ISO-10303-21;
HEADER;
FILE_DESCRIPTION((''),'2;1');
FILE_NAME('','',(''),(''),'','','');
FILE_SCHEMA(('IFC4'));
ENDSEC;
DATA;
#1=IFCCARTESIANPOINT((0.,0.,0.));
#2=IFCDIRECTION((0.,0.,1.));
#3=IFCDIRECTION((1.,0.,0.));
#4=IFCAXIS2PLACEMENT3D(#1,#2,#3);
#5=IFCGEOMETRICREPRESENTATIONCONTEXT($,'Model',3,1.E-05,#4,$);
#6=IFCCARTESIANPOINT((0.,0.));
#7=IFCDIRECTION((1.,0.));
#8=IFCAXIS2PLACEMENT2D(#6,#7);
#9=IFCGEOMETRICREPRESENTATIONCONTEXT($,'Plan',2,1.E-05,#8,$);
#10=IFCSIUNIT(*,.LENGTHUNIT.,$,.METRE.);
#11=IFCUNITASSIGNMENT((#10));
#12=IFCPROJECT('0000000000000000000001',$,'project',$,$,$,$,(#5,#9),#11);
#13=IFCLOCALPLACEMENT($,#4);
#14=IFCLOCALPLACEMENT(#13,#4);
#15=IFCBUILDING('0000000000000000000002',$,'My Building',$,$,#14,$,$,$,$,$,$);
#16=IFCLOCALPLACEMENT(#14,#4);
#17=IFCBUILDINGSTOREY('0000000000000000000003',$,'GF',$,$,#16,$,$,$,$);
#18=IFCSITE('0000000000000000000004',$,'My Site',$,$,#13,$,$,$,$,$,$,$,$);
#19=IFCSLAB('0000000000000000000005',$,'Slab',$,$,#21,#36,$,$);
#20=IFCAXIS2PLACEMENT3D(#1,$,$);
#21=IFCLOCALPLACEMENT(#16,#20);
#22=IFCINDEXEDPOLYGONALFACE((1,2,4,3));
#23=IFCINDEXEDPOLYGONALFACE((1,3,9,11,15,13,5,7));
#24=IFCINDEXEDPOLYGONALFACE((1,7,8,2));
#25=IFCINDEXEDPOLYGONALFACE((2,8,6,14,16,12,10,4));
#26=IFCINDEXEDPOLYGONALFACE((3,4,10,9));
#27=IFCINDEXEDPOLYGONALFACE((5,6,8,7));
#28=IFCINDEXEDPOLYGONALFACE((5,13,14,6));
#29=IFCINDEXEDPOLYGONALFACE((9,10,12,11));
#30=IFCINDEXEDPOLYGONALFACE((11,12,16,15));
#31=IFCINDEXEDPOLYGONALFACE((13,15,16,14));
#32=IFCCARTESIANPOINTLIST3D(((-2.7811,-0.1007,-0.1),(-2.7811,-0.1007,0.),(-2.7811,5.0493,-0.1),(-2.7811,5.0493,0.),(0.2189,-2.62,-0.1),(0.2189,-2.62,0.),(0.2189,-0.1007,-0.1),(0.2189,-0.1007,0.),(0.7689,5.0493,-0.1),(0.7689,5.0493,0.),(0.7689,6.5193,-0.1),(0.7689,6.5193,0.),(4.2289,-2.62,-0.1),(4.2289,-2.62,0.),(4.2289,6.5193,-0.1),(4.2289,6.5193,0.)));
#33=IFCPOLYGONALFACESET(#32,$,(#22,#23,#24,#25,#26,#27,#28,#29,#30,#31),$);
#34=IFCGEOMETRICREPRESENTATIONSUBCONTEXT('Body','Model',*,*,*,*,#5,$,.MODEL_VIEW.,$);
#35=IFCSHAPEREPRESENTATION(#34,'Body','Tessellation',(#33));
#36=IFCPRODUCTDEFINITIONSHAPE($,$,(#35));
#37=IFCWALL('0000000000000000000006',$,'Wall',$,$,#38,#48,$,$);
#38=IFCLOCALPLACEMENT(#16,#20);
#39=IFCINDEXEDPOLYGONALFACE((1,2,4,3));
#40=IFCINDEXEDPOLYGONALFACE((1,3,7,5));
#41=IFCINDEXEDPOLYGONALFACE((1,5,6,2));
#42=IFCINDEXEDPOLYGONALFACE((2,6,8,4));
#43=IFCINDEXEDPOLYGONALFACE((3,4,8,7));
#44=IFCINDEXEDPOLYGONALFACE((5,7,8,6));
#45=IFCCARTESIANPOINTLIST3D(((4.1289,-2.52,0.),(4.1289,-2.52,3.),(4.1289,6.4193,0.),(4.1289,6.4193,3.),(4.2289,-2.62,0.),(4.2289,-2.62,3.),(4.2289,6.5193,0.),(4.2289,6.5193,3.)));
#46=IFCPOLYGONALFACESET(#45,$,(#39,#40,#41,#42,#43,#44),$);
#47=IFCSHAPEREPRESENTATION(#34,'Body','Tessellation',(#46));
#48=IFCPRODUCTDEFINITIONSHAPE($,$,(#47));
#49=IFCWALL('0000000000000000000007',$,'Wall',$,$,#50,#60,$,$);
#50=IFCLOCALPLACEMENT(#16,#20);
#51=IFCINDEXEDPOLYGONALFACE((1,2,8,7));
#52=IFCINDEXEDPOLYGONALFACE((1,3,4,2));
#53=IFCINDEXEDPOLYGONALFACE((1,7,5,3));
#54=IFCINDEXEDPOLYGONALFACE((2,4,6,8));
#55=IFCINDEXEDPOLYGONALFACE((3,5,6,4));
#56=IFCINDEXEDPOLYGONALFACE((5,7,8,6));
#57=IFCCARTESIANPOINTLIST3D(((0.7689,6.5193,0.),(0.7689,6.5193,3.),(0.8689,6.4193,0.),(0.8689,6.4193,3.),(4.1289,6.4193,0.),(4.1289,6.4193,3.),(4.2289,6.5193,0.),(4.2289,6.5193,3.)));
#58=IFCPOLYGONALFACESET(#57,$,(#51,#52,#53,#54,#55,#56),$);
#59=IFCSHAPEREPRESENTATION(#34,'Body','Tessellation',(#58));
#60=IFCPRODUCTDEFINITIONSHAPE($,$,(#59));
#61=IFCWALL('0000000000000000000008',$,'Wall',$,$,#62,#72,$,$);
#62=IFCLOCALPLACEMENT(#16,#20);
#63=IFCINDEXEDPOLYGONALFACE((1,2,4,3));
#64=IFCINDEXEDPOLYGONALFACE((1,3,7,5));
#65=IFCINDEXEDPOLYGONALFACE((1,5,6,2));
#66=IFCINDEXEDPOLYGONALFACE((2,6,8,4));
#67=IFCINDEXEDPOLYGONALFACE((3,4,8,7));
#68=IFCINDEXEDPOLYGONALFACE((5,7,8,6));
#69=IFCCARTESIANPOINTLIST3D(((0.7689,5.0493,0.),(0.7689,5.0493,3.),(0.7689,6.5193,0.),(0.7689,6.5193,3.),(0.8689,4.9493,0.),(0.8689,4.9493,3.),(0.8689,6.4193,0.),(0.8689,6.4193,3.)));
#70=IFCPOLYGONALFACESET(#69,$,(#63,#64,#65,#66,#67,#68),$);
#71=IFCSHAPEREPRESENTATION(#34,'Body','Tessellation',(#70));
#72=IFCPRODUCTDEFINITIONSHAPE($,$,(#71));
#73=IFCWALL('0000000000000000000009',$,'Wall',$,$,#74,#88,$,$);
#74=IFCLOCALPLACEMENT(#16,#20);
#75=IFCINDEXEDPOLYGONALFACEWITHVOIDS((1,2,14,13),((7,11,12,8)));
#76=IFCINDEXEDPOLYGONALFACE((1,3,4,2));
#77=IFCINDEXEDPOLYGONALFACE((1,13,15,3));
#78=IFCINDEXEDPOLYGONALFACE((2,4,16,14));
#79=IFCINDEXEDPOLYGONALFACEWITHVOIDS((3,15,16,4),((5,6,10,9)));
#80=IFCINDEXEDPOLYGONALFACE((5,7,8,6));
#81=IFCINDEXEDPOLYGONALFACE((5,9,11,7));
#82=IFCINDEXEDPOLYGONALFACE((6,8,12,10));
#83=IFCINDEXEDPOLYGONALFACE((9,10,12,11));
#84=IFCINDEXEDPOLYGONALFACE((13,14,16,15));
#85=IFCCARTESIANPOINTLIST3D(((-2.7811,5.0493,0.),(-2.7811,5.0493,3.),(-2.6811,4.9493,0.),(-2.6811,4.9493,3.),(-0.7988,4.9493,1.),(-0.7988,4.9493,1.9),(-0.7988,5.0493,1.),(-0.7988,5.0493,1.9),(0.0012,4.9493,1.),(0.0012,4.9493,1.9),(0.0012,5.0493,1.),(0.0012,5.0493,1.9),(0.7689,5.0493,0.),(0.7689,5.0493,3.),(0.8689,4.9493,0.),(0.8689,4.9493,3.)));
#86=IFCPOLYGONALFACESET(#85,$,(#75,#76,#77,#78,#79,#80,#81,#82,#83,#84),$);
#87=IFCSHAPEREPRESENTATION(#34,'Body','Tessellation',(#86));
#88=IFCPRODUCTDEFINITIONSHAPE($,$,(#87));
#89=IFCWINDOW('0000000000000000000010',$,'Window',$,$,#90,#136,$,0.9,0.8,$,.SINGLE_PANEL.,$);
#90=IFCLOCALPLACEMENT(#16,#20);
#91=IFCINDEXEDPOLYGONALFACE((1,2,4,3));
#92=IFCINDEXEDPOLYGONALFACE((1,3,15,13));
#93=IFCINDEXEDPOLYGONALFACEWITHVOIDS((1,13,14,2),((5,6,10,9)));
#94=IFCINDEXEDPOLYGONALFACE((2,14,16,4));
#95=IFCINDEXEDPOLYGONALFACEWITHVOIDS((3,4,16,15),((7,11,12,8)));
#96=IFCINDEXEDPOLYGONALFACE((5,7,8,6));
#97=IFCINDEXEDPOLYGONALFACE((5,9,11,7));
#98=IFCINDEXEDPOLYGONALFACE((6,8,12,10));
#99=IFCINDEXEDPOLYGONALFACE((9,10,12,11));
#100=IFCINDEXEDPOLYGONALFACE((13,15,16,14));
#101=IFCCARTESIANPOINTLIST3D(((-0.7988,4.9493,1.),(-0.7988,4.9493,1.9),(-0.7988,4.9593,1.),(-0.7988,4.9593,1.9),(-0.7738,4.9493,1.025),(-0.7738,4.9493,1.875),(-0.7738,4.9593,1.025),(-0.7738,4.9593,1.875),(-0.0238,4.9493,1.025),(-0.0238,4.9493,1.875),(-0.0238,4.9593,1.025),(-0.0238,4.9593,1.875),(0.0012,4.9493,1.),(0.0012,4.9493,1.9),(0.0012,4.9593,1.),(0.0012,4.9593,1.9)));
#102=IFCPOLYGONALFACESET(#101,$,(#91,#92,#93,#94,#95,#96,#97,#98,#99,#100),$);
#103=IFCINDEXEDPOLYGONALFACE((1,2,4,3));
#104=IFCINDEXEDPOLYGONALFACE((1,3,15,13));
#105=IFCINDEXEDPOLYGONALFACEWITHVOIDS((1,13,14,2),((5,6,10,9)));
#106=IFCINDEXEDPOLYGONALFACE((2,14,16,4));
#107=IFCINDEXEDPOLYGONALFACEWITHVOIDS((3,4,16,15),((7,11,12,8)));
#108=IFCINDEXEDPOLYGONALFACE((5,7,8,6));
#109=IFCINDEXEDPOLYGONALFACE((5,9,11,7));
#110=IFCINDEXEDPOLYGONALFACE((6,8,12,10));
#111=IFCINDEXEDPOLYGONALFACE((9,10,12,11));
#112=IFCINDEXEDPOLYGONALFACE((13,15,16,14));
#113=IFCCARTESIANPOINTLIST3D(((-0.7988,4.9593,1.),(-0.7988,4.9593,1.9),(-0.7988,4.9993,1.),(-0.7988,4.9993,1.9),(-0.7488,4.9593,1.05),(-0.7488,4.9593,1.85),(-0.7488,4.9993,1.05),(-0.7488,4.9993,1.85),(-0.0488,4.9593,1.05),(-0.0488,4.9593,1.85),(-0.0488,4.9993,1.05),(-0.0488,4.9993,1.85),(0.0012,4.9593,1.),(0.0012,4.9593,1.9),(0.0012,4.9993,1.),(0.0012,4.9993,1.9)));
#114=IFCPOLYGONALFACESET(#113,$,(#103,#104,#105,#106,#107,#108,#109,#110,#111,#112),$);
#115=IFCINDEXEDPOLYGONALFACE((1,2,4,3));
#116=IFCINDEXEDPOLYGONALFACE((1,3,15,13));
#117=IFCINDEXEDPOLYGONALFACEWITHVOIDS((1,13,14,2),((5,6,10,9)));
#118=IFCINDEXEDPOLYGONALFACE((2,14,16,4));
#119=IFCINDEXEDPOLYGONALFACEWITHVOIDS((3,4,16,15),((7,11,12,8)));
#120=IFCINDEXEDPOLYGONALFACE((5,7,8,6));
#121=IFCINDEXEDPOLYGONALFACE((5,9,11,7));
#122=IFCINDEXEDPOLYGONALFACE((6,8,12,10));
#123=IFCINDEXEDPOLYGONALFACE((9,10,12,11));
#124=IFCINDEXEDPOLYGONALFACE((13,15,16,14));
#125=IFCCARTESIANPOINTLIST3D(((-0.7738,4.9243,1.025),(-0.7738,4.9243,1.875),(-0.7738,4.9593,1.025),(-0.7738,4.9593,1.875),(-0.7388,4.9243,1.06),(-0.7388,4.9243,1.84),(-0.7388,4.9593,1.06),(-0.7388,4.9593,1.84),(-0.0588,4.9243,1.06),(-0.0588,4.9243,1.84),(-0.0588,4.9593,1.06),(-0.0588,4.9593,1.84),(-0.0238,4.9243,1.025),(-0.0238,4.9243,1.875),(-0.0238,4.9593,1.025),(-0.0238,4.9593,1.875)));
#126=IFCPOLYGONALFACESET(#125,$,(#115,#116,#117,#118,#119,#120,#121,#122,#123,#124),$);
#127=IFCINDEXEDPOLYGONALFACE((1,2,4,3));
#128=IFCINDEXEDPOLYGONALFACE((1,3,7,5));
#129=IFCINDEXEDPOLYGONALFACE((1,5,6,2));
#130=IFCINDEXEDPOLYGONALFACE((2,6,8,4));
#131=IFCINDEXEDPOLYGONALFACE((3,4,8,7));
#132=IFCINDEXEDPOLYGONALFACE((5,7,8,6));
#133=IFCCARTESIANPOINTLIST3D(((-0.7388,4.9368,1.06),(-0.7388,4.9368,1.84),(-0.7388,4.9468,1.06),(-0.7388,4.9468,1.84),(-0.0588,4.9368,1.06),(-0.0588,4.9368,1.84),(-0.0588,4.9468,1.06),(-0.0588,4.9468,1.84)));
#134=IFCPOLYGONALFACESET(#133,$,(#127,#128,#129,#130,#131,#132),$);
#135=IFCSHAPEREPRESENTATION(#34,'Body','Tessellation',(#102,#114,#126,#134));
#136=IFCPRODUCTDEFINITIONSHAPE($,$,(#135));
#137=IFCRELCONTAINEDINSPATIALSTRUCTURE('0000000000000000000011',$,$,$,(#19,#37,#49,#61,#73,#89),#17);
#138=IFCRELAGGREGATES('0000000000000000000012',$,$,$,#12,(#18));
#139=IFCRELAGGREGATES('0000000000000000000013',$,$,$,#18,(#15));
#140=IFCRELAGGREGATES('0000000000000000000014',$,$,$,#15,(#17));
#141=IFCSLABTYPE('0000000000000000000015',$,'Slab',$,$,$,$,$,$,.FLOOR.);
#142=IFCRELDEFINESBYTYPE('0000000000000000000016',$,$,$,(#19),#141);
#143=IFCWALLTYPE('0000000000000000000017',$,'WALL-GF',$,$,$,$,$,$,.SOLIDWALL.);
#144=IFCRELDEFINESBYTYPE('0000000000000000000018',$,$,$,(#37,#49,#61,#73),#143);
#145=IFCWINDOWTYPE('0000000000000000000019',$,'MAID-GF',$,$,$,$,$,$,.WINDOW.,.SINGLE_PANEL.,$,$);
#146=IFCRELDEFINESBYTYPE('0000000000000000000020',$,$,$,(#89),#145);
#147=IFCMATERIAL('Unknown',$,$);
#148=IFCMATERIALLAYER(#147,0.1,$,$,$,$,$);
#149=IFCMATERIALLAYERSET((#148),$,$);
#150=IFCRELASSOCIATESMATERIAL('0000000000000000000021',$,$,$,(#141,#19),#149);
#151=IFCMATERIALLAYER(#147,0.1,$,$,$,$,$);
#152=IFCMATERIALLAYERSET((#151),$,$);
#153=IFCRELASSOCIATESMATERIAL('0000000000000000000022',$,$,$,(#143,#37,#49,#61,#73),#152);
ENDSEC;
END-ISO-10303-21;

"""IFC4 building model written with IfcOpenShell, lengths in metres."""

from ifc_helpers import new_model, entity, si_unit, frame, origin_with_axes, origin_2d_with_axis, place, context, subcontext, project, spatial, line, indexed_curve, outline, extrude, shape, source, transform, mapped, material, layer, layer_set, layer_usage, type_object, type_shapes, element, fill, save


model = new_model("IFC4")

# Units and contexts
model_context = context("Model", 3, precision=1e-05, world=origin_with_axes())
plan_context = context("Plan", 2, precision=1e-05, world=origin_2d_with_axis())
body_context_1 = subcontext(model_context, "Body", "Model", "MODEL_VIEW")
body_context_2 = subcontext(plan_context, "Body", "Plan", "PLAN_VIEW")
ifc_project = project(units=[si_unit("LENGTHUNIT", "METRE")], contexts=[model_context, plan_context])

# Site, building, storey
site_placement = place(None, origin_with_axes())
site = spatial("IfcSite", under=ifc_project, at=site_placement, Name="My Site")
building_placement = place(site_placement, origin_with_axes())
building = spatial("IfcBuilding", under=site, at=building_placement, Name="My Building")
storey_placement = place(building_placement, origin_with_axes())
storey = spatial("IfcBuildingStorey", under=building, at=storey_placement, Name="GF")

# Slab
ifc_material = material(Name="Unknown")
ifc_layer_1 = layer(ifc_material, 0.1)
ifc_layer_set_1 = layer_set([ifc_layer_1])
ifc_layer_usage_1 = layer_usage(ifc_layer_set_1, "AXIS3", "POSITIVE", -0.1)
slab_type = type_object("IfcSlabType", Name="Slab", PredefinedType="FLOOR", material=ifc_layer_set_1)
slab_placement = place(storey_placement, frame((4.2289, 6.5193, 0.0), z_axis=(0.0, 0.0, 1.0), x_axis=(1.0, 0.0, 0.0)))
element("IfcSlab", 1, at=slab_placement, inside=storey, type_object=slab_type, material=ifc_layer_usage_1, Name="Slab", context=body_context_1, shape_type="SweptSolid", body=[
    extrude(outline(indexed_curve([(0.0, 0.0), (-3.46, 0.0), (-3.46, -1.47), (-7.01, -1.47), (-7.01, -6.62), (-4.01, -6.62), (-4.01, -9.1393), (0.0, -9.1393), (0.0, 0.0)])), frame((0.0, 0.0, -0.1), z_axis=(0.0, 0.0, 1.0), x_axis=(1.0, 0.0, 0.0)), (0.0, 0.0, 1.0), 0.1),
])

# Shared definitions
ifc_layer_2 = layer(ifc_material, 0.1)
ifc_layer_set_2 = layer_set([ifc_layer_2])
wall_type = type_object("IfcWallType", Name="WALL-GF", PredefinedType="SOLIDWALL", material=ifc_layer_set_2)

# Walls
ifc_layer_usage_2 = layer_usage(ifc_layer_set_2, "AXIS2", "POSITIVE", 0.0)
wall_1_placement = place(storey_placement, frame((4.2289, -2.62, 0.0), z_axis=(0.0, 0.0, 1.0), x_axis=(0.0, 1.0, 0.0)))
element("IfcWall", 2, at=wall_1_placement, inside=storey, type_object=wall_type, material=ifc_layer_usage_2, Name="Wall", context=body_context_1, shape_type="SweptSolid", body=[
    extrude(outline(indexed_curve([(0.0, 0.0), (0.1, 0.1), (9.0393, 0.1), (9.1393, 0.0)], segments=[line(1, 2, 3, 4, 1)])), origin_with_axes(), (0.0, 0.0, 1.0), 3.0),
])
ifc_layer_usage_3 = layer_usage(ifc_layer_set_2, "AXIS2", "POSITIVE", 0.0)
wall_2_placement = place(storey_placement, frame((4.2289, 6.5193, 0.0), z_axis=(0.0, 0.0, 1.0), x_axis=(-1.0, 0.0, 0.0)))
element("IfcWall", 3, at=wall_2_placement, inside=storey, type_object=wall_type, material=ifc_layer_usage_3, Name="Wall", context=body_context_1, shape_type="SweptSolid", body=[
    extrude(outline(indexed_curve([(0.0, 0.0), (0.1, 0.1), (3.36, 0.1), (3.46, 0.0)], segments=[line(1, 2, 3, 4, 1)])), origin_with_axes(), (0.0, 0.0, 1.0), 3.0),
])
ifc_layer_usage_4 = layer_usage(ifc_layer_set_2, "AXIS2", "POSITIVE", 0.0)
wall_3_placement = place(storey_placement, frame((0.7689, 6.5193, 0.0), z_axis=(0.0, 0.0, 1.0), x_axis=(0.0, -1.0, 0.0)))
element("IfcWall", 4, at=wall_3_placement, inside=storey, type_object=wall_type, material=ifc_layer_usage_4, Name="Wall", context=body_context_1, shape_type="SweptSolid", body=[
    extrude(outline(indexed_curve([(0.0, 0.0), (0.1, 0.1), (1.57, 0.1), (1.47, 0.0)], segments=[line(1, 2, 3, 4, 1)])), origin_with_axes(), (0.0, 0.0, 1.0), 3.0),
])

# Wall, opening, window
ifc_layer_usage_5 = layer_usage(ifc_layer_set_2, "AXIS2", "POSITIVE", 0.0)
wall_4_placement = place(storey_placement, frame((0.7689, 5.0493, 0.0), z_axis=(0.0, 0.0, 1.0), x_axis=(-1.0, 0.0, 0.0)))
wall_4 = element("IfcWall", 5, at=wall_4_placement, inside=storey, type_object=wall_type, material=ifc_layer_usage_5, Name="Wall", context=body_context_1, shape_type="SweptSolid", body=[
    extrude(outline(indexed_curve([(0.0, 0.0), (-0.1, 0.1), (3.45, 0.1), (3.55, 0.0)], segments=[line(1, 2, 3, 4, 1)])), origin_with_axes(), (0.0, 0.0, 1.0), 3.0),
])
shared_shape_1 = source(origin_with_axes(), body_context_1, "Body", "SweptSolid", [
    extrude(outline(indexed_curve([(0.0, 0.0), (0.8, 0.0), (0.8, 0.9), (0.0, 0.9)], segments=[line(1, 2, 3, 4, 1)])), frame((0.0, -0.6, 0.0), z_axis=(0.0, -1.0, 0.0), x_axis=(1.0, 0.0, 0.0)), (0.0, 0.0, -1.0), 1.2),
])
opening_1_placement = place(wall_4_placement, frame((0.7678, 0.0, 1.0), z_axis=(0.0, 0.0, 1.0), x_axis=(1.0, 0.0, 0.0)))
opening_1 = element("IfcOpeningElement", 6, at=opening_1_placement, cuts=wall_4, PredefinedType="OPENING", context=body_context_1, shape_type="MappedRepresentation", body=[
    mapped(shared_shape_1, transform((0.0, 0.0, 0.0), x_axis=(1.0, 0.0, 0.0), y_axis=(0.0, 1.0, 0.0), z_axis=(0.0, 0.0, 1.0), scale=1.0)),
])
window_type_1 = type_object("IfcWindowType", Name="MAID-GF", PartitioningType="SINGLE_PANEL", PredefinedType="WINDOW")
shared_shape_2 = source(origin_with_axes(), body_context_1, "Body", "SweptSolid", [
    extrude(outline(indexed_curve([(0.0, 0.0), (0.8, 0.0), (0.8, 0.9), (0.0, 0.9)], segments=[line(1, 2, 3, 4, 1)]), holes=[indexed_curve([(0.025, 0.025), (0.775, 0.025), (0.775, 0.875), (0.025, 0.875)], segments=[line(1, 2, 3, 4, 1)])]), frame((0.0, 0.09, 0.0), z_axis=(0.0, -1.0, 0.0), x_axis=(1.0, 0.0, 0.0)), (0.0, 0.0, -1.0), 0.01),
    extrude(outline(indexed_curve([(0.0, 0.0), (0.8, 0.0), (0.8, 0.9), (0.0, 0.9)], segments=[line(1, 2, 3, 4, 1)]), holes=[indexed_curve([(0.05, 0.05), (0.75, 0.05), (0.75, 0.85), (0.05, 0.85)], segments=[line(1, 2, 3, 4, 1)])]), frame((0.0, 0.05, 0.0), z_axis=(0.0, -1.0, 0.0), x_axis=(1.0, 0.0, 0.0)), (0.0, 0.0, -1.0), 0.04),
    extrude(outline(indexed_curve([(0.0, 0.0), (0.75, 0.0), (0.75, 0.85), (0.0, 0.85)], segments=[line(1, 2, 3, 4, 1)]), holes=[indexed_curve([(0.035, 0.035), (0.715, 0.035), (0.715, 0.815), (0.035, 0.815)], segments=[line(1, 2, 3, 4, 1)])]), frame((0.025, 0.09, 0.025), z_axis=(0.0, -1.0, 0.0), x_axis=(1.0, 0.0, 0.0)), (0.0, 0.0, -1.0), 0.035),
    extrude(outline(indexed_curve([(0.035, 0.035), (0.715, 0.035), (0.715, 0.815), (0.035, 0.815)], segments=[line(1, 2, 3, 4, 1)])), frame((0.025, 0.1025, 0.025), z_axis=(0.0, -1.0, 0.0), x_axis=(1.0, 0.0, 0.0)), (0.0, 0.0, -1.0), 0.01),
])
shared_shape_3 = source(origin_with_axes(), body_context_2, "Body", "Curve2D", [
    entity("IfcIndexedPolyCurve", entity("IfcCartesianPointList2D", [[0.05, 0.05], [0.75, 0.05]])),
    entity("IfcIndexedPolyCurve", entity("IfcCartesianPointList2D", [[0.0, 0.1], [0.025, 0.1], [0.025, 0.09], [0.05, 0.09], [0.05, 0.05], [0.0, 0.05]]), [entity("IfcLineIndex", [1, 2, 3, 4, 5, 6, 1])]),
    entity("IfcIndexedPolyCurve", entity("IfcCartesianPointList2D", [[0.8, 0.1], [0.775, 0.1], [0.775, 0.09], [0.75, 0.09], [0.75, 0.05], [0.8, 0.05]]), [entity("IfcLineIndex", [1, 2, 3, 4, 5, 6, 1])]),
    entity("IfcIndexedPolyCurve", entity("IfcCartesianPointList2D", [[0.025, 0.09], [0.06, 0.09], [0.06, 0.125], [0.025, 0.125]]), [entity("IfcLineIndex", [1, 2, 3, 4, 1])]),
    entity("IfcIndexedPolyCurve", entity("IfcCartesianPointList2D", [[0.775, 0.09], [0.74, 0.09], [0.74, 0.125], [0.775, 0.125]]), [entity("IfcLineIndex", [1, 2, 3, 4, 1])]),
    entity("IfcIndexedPolyCurve", entity("IfcCartesianPointList2D", [[0.06, 0.09], [0.74, 0.09]])),
    entity("IfcIndexedPolyCurve", entity("IfcCartesianPointList2D", [[0.06, 0.125], [0.74, 0.125]])),
    entity("IfcIndexedPolyCurve", entity("IfcCartesianPointList2D", [[0.06, 0.1075], [0.74, 0.1075]])),
])
type_shapes(window_type_1, [shared_shape_2, shared_shape_3])
window_1_placement = place(opening_1_placement, frame((0.0, 0.0, 0.0), z_axis=(0.0, 0.0, 1.0), x_axis=(1.0, 0.0, 0.0)))
window_1 = element("IfcWindow", 7, at=window_1_placement, inside=storey, type_object=window_type_1, Name="Window", OverallHeight=0.9, OverallWidth=0.8, PartitioningType="SINGLE_PANEL", shapes=[
    shape(body_context_1, "Body", "MappedRepresentation", [mapped(shared_shape_2, transform((0.0, 0.0, 0.0), x_axis=(1.0, 0.0, 0.0), y_axis=(0.0, 1.0, 0.0), z_axis=(0.0, 0.0, 1.0), scale=1.0))]),
    shape(body_context_2, "Body", "MappedRepresentation", [mapped(shared_shape_3, transform((0.0, 0.0, 0.0), x_axis=(1.0, 0.0, 0.0), y_axis=(0.0, 1.0, 0.0), z_axis=(0.0, 0.0, 1.0), scale=1.0))]),
])
fill(opening_1, window_1)

save(model, "model.ifc")
